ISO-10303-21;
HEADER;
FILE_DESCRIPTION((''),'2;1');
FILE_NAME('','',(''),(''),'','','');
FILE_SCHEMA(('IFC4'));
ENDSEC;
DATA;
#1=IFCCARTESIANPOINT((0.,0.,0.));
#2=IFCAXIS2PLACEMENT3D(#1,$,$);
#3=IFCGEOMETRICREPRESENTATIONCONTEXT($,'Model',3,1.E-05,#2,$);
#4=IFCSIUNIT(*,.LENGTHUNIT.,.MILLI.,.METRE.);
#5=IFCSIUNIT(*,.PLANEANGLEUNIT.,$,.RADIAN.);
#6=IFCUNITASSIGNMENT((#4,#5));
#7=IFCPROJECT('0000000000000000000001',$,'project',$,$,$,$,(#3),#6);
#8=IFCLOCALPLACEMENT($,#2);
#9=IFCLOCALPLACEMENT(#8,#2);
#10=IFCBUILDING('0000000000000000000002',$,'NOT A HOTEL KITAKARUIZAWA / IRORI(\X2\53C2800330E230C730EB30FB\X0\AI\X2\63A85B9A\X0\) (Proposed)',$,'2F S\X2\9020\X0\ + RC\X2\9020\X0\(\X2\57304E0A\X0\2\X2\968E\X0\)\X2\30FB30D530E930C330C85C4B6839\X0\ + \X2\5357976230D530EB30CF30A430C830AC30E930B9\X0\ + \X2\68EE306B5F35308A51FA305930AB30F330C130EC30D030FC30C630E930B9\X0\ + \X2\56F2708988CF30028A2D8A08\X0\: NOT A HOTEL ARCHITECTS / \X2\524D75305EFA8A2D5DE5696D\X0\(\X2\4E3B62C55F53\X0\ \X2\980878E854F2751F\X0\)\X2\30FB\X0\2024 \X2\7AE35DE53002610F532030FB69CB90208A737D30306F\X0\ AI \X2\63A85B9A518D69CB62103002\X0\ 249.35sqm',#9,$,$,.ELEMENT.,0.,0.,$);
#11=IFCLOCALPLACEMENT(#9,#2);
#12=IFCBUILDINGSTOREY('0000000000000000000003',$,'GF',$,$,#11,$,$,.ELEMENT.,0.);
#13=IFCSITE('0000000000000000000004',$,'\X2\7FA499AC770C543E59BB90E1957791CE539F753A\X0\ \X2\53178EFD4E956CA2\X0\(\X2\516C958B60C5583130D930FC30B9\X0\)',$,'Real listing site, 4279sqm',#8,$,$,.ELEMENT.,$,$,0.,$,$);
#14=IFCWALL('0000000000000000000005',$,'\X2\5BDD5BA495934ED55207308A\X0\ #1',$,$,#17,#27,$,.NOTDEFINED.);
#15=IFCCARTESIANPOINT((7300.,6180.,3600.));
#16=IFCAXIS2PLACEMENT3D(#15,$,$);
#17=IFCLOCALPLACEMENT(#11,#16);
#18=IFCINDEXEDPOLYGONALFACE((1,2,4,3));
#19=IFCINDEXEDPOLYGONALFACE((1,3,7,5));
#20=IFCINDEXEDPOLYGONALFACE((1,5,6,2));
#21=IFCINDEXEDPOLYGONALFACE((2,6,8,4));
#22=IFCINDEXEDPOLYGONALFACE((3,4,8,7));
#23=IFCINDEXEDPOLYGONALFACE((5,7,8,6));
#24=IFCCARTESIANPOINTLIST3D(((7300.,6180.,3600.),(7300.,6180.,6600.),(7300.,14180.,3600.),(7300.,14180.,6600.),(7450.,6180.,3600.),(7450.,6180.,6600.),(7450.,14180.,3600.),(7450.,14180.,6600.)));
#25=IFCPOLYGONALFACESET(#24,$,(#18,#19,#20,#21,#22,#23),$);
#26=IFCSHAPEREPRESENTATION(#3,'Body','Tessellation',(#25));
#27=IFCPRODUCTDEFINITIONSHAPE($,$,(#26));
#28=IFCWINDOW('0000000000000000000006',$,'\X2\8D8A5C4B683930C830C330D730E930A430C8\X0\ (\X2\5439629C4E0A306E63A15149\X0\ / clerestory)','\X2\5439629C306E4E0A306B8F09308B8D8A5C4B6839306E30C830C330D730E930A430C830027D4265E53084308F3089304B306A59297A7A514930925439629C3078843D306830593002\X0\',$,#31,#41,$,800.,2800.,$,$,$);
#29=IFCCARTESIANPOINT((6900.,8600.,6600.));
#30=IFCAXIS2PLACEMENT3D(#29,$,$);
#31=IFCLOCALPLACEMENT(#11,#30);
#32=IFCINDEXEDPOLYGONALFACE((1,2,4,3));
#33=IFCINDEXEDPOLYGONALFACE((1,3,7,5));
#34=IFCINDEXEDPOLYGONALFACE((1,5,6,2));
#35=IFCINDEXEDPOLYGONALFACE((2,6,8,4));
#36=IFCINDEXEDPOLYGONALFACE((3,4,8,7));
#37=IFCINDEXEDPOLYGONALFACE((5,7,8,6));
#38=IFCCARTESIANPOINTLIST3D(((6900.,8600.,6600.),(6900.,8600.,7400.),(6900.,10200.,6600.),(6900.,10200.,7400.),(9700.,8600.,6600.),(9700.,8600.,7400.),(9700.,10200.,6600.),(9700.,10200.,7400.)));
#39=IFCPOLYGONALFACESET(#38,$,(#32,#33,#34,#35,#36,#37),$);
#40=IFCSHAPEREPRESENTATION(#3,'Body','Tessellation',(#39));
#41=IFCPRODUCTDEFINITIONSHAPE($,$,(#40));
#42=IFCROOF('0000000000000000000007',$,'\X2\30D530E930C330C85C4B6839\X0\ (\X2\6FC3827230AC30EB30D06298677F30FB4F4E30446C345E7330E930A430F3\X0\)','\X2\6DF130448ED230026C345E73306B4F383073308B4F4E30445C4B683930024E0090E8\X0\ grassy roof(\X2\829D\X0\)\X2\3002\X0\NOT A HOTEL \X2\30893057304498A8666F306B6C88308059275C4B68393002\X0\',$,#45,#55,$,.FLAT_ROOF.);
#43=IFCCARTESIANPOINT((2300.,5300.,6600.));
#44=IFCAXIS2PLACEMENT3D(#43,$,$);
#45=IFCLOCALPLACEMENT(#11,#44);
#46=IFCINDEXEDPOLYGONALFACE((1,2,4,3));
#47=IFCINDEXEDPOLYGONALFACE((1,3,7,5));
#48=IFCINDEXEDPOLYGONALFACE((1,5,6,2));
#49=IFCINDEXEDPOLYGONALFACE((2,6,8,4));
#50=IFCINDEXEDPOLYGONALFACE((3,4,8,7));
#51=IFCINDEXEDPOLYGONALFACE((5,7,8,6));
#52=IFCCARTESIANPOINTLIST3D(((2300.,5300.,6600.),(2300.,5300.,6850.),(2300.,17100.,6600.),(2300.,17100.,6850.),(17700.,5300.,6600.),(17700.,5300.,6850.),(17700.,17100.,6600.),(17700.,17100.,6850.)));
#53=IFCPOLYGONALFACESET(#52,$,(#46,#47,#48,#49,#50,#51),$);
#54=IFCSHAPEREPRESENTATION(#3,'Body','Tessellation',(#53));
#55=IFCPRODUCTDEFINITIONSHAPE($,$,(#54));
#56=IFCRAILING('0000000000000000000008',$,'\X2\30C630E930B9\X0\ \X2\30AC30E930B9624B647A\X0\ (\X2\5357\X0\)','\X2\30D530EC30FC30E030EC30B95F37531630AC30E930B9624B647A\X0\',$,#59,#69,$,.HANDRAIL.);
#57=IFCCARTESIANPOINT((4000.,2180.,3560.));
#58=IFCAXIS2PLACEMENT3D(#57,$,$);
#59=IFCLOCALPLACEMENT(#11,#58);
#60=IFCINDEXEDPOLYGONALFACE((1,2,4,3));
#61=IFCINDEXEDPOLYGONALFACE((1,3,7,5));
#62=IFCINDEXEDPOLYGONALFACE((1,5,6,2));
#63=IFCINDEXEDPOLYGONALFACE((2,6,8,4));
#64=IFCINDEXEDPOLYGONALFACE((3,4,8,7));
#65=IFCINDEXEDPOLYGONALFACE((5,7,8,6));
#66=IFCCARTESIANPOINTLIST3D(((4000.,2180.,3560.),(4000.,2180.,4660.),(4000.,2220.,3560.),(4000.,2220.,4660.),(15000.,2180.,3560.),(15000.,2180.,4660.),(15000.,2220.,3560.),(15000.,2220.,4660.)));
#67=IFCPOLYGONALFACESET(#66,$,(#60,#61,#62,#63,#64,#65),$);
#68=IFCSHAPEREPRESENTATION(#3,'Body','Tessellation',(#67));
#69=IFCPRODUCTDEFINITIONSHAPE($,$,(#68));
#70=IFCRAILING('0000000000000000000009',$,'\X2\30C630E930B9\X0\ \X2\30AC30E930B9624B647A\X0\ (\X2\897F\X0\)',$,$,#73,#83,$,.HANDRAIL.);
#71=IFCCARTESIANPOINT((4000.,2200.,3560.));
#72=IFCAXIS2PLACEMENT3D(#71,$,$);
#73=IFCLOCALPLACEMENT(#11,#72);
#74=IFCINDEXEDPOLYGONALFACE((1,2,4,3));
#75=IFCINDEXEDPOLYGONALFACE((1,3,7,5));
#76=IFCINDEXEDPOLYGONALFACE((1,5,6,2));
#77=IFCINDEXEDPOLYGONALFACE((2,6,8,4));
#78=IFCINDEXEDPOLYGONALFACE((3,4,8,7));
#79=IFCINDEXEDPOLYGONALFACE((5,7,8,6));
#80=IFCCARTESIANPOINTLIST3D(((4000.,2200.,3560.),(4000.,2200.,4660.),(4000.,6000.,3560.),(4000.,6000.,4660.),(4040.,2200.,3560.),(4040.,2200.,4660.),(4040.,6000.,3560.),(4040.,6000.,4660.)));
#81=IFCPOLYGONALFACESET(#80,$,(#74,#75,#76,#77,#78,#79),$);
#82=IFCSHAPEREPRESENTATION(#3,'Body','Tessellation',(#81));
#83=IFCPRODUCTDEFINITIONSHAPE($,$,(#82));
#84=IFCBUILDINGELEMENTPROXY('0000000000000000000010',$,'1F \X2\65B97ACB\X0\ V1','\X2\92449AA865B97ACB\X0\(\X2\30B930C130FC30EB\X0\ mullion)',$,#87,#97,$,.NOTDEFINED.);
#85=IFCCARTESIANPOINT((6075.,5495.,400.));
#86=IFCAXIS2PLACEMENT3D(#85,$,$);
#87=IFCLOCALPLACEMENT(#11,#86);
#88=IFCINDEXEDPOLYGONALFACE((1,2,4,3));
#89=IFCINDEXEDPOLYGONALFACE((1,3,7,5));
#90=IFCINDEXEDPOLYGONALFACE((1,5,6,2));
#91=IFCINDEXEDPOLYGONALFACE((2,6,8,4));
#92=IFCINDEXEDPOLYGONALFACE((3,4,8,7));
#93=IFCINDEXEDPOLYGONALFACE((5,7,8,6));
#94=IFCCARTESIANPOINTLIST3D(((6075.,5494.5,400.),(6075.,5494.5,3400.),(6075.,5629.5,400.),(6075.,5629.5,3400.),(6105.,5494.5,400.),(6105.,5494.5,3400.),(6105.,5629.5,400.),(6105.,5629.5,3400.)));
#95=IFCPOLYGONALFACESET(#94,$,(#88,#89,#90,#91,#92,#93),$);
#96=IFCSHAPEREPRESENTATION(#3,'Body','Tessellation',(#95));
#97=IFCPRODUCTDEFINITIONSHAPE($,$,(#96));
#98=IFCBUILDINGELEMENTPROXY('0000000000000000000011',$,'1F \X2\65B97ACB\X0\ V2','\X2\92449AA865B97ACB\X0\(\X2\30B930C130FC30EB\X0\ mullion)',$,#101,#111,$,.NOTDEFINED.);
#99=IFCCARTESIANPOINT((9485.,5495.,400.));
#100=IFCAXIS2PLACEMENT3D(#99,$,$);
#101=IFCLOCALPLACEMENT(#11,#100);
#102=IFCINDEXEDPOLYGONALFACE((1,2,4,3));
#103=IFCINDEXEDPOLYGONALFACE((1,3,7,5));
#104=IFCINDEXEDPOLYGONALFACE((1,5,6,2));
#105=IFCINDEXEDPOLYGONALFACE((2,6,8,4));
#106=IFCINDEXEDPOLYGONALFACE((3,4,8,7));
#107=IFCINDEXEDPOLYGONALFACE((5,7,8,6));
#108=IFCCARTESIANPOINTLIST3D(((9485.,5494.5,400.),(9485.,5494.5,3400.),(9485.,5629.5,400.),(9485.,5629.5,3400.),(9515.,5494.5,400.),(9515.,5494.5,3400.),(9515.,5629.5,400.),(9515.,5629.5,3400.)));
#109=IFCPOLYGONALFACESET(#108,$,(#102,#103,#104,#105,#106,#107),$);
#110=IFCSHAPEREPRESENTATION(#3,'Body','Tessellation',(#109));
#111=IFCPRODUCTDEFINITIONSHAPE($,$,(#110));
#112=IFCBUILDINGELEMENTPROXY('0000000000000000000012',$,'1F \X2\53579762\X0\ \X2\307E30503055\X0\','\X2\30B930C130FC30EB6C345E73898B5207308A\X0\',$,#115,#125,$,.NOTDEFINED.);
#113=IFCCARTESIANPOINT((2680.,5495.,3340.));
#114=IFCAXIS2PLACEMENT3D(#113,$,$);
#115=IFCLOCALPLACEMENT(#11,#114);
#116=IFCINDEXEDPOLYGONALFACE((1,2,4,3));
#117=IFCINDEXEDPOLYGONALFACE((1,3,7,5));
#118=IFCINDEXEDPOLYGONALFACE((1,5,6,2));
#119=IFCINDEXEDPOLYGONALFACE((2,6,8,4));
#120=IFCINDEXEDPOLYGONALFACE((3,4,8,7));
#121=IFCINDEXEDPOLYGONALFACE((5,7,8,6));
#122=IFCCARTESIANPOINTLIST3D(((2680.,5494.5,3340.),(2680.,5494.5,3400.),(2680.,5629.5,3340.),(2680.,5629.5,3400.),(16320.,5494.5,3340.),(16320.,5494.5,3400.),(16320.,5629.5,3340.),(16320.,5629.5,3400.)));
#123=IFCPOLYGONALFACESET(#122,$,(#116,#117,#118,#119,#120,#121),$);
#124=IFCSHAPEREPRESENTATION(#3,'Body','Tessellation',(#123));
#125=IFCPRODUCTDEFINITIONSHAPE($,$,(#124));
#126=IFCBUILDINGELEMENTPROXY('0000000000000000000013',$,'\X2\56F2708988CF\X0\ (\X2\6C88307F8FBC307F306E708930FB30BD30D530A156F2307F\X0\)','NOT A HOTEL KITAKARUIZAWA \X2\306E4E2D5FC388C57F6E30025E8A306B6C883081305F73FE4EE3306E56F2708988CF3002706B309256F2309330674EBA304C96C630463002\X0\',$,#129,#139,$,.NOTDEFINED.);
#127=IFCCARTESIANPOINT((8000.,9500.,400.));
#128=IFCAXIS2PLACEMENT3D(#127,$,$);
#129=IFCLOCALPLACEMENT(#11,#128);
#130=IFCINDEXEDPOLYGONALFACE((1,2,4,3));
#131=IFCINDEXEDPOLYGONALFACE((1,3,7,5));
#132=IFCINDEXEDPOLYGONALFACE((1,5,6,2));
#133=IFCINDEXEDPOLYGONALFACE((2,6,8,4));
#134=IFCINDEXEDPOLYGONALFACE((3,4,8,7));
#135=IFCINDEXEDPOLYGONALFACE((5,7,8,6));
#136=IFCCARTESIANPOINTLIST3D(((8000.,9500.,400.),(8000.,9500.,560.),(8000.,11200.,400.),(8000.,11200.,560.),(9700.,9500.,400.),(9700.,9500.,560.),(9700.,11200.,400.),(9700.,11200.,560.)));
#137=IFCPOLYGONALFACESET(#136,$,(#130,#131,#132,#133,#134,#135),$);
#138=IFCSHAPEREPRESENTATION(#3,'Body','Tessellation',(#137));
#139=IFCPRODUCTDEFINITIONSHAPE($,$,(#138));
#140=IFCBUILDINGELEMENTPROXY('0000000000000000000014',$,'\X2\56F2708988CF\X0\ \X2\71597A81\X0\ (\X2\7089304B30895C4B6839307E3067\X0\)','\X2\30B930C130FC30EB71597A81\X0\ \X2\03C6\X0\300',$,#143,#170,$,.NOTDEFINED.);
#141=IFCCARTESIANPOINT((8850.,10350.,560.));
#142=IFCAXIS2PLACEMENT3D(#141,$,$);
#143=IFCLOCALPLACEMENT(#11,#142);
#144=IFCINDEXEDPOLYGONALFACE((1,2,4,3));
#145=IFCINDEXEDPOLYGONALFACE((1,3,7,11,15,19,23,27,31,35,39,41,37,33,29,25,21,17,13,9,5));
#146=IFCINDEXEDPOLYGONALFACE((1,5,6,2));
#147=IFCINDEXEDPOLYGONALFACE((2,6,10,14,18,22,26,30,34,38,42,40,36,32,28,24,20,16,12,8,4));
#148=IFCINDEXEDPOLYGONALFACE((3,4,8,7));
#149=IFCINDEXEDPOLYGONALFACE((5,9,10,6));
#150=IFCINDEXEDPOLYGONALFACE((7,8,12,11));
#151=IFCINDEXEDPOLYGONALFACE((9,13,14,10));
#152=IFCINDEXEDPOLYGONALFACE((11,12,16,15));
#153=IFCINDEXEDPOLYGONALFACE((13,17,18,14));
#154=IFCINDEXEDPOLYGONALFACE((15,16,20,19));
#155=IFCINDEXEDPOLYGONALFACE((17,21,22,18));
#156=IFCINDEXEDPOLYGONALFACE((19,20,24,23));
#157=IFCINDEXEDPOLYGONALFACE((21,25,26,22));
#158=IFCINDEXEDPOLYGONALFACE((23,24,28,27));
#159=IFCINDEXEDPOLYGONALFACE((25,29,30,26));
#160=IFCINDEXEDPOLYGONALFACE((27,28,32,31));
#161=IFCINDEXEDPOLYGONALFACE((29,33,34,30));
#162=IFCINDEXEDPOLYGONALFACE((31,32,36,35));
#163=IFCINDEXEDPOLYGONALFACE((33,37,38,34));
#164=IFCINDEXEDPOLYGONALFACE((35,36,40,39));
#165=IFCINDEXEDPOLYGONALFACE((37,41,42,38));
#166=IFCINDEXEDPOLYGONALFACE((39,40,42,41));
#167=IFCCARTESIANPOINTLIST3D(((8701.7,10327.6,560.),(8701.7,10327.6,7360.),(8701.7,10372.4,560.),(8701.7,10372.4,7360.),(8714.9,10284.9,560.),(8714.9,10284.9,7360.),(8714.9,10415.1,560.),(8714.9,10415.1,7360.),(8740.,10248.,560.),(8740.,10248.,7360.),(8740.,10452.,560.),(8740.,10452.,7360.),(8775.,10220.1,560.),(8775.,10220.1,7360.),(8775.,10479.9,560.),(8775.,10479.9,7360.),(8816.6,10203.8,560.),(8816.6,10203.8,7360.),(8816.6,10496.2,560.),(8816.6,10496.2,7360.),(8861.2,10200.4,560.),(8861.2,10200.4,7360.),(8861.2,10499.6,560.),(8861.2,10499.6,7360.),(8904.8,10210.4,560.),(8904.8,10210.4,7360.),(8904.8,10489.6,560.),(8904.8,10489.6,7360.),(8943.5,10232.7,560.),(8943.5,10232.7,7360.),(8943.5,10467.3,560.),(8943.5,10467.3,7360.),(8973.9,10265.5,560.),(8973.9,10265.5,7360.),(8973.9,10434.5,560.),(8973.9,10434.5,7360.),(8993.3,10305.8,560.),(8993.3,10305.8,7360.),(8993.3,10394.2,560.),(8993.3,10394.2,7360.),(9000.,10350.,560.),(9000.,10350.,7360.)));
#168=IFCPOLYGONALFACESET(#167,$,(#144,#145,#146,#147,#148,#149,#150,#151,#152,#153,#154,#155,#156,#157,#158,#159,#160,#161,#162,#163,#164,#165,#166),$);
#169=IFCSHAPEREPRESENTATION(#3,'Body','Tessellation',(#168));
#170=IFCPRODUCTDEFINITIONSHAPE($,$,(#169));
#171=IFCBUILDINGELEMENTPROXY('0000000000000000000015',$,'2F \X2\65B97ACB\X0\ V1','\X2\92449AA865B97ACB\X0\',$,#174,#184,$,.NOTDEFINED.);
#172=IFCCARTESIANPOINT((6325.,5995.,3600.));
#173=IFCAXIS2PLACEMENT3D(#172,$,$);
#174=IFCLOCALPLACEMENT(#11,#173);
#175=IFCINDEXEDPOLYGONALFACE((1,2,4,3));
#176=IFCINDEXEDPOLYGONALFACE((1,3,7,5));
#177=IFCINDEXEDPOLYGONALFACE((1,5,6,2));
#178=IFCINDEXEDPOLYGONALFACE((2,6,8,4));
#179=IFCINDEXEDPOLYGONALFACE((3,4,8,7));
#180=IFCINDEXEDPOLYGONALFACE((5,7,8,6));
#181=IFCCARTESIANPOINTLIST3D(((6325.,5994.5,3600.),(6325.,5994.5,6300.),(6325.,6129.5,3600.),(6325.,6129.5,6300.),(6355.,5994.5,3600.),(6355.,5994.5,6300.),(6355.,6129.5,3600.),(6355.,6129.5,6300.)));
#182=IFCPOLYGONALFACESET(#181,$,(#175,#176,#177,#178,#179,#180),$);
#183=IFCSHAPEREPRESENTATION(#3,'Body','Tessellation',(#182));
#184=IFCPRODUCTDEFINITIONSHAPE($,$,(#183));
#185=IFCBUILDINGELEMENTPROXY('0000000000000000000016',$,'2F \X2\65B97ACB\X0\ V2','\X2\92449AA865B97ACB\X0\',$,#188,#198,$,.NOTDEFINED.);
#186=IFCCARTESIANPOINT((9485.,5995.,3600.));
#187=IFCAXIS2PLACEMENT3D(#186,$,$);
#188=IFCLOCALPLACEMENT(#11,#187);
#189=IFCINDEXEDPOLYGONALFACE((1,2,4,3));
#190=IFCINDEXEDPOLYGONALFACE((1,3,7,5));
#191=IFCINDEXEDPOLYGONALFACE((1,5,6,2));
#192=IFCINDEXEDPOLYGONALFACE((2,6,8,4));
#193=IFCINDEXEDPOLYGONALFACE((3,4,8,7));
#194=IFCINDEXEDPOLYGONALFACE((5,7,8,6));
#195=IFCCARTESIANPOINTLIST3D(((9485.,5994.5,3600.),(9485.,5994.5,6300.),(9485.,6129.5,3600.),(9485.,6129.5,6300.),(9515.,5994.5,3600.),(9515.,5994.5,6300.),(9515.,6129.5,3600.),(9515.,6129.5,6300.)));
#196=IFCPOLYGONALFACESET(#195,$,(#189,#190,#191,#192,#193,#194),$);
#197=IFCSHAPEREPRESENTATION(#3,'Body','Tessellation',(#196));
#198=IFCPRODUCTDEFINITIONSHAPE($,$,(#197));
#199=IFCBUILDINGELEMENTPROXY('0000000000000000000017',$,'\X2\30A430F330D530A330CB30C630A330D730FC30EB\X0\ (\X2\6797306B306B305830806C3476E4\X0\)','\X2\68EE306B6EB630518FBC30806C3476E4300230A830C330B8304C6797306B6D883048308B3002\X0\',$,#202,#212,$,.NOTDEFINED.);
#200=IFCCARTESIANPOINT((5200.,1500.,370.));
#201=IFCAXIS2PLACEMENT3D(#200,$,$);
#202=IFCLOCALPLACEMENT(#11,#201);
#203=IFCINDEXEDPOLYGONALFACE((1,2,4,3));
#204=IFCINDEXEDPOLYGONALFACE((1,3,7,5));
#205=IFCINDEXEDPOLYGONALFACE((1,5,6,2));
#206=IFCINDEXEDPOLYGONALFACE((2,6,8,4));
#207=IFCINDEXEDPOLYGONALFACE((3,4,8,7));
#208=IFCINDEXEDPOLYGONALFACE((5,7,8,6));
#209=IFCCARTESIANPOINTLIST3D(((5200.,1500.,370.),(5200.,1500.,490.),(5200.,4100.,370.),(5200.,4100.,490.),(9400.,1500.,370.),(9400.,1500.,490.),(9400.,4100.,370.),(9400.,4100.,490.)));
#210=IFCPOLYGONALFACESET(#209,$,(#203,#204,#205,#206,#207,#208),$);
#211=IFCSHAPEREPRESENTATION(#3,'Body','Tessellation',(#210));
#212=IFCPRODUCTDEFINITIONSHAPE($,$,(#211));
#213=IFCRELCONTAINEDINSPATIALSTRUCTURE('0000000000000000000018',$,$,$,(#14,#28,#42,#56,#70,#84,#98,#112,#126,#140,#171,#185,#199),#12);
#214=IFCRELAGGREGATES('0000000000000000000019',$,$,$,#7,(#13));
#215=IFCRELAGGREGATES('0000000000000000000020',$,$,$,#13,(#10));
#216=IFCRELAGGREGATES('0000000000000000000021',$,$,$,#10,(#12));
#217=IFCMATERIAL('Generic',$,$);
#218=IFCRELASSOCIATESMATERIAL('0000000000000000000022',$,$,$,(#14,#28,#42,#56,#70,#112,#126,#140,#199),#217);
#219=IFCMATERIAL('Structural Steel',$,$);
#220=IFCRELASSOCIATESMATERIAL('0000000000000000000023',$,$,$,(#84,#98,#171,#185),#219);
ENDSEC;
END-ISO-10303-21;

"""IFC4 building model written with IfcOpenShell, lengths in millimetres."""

from ifc_helpers import new_model, si_unit, frame, frame_2d, origin, origin_2d, place, context, project, spatial, rectangle, circle, extrude, material, element, save


model = new_model("IFC4")

# Units and contexts
model_context = context("Model", 3, precision=1e-05, world=origin())
ifc_project = project(units=[si_unit("LENGTHUNIT", "METRE", prefix="MILLI"), si_unit("PLANEANGLEUNIT", "RADIAN")], contexts=[model_context])

# Site, building, storey
site_placement = place(None, origin())
site = spatial("IfcSite", under=ifc_project, at=site_placement, Name="群馬県吾妻郡長野原町 北軽井沢(公開情報ベース)", ObjectType="Real listing site, 4279sqm", CompositionType="ELEMENT", RefElevation=0.0)
building_placement = place(site_placement, origin())
building = spatial("IfcBuilding", under=site, at=building_placement, Name="NOT A HOTEL KITAKARUIZAWA / IRORI(参考モデル・AI推定) (Proposed)", ObjectType="2F S造 + RC造(地上2階)・フラット屋根 + 南面フルハイトガラス + 森に張り出すカンチレバーテラス + 囲炉裏。設計: NOT A HOTEL ARCHITECTS / 前田建設工業(主担当 須磨哲生)・2024 竣工。意匠・構造詳細は AI 推定再構成。 249.35sqm", CompositionType="ELEMENT", ElevationOfRefHeight=0.0, ElevationOfTerrain=0.0)
storey_placement = place(building_placement, origin())
storey = spatial("IfcBuildingStorey", under=building, at=storey_placement, Name="GF", CompositionType="ELEMENT", Elevation=0.0)

# Shared definitions
ifc_material_1 = material(Name="Structural Steel")

# Shared definitions
ifc_material_2 = material(Name="Generic")

# Wall
wall_1_placement = place(storey_placement, frame((7300.0, 6180.0, 3600.0)))
element("IfcWall", 1, at=wall_1_placement, inside=storey, material=ifc_material_2, Name="寝室間仕切り #1", PredefinedType="NOTDEFINED", context=model_context, shape_type="SweptSolid", body=[
    extrude(rectangle(XDim=150.0, YDim=8000.0, at=frame_2d((75.0, 4000.0))), frame((7300.0, 6180.0, 3600.0)), (0.0, 0.0, 1.0), 3000.0),
])

# Window
window_1_placement = place(storey_placement, frame((6900.0, 8600.0, 6600.0)))
element("IfcWindow", 2, at=window_1_placement, inside=storey, material=ifc_material_2, Name="越屋根トップライト (吹抜上の採光 / clerestory)", Description="吹抜の上に載る越屋根のトップライト。終日やわらかな天空光を吹抜へ落とす。", OverallHeight=800.0, OverallWidth=2800.0, context=model_context, shape_type="SweptSolid", body=[
    extrude(rectangle(XDim=2800.0, YDim=1600.0, at=frame_2d((1400.0, 800.0))), frame((6900.0, 8600.0, 6600.0)), (0.0, 0.0, 1.0), 800.0),
])

# Roof
roof_placement = place(storey_placement, frame((2300.0, 5300.0, 6600.0)))
element("IfcRoof", 3, at=roof_placement, inside=storey, material=ifc_material_2, Name="フラット屋根 (濃色ガルバ折板・低い水平ライン)", Description="深い軒。水平に伸びる低い屋根。一部 grassy roof(芝)。NOT A HOTEL らしい風景に沈む大屋根。", PredefinedType="FLAT_ROOF", context=model_context, shape_type="SweptSolid", body=[
    extrude(rectangle(XDim=15400.0, YDim=11800.0, at=frame_2d((7700.0, 5900.0))), frame((2300.0, 5300.0, 6600.0)), (0.0, 0.0, 1.0), 250.0),
])

# Railings
railing_1_placement = place(storey_placement, frame((4000.0, 2180.0, 3560.0)))
element("IfcRailing", 4, at=railing_1_placement, inside=storey, material=ifc_material_2, Name="テラス ガラス手摺 (南)", Description="フレームレス強化ガラス手摺", PredefinedType="HANDRAIL", context=model_context, shape_type="SweptSolid", body=[
    extrude(rectangle(XDim=11000.0, YDim=40.0, at=frame_2d((5500.0, 20.0))), frame((4000.0, 2180.0, 3560.0)), (0.0, 0.0, 1.0), 1100.0),
])
railing_2_placement = place(storey_placement, frame((4000.0, 2200.0, 3560.0)))
element("IfcRailing", 5, at=railing_2_placement, inside=storey, material=ifc_material_2, Name="テラス ガラス手摺 (西)", PredefinedType="HANDRAIL", context=model_context, shape_type="SweptSolid", body=[
    extrude(rectangle(XDim=40.0, YDim=3800.0, at=frame_2d((20.0, 1900.0))), frame((4000.0, 2200.0, 3560.0)), (0.0, 0.0, 1.0), 1100.0),
])

# Building element proxies
proxy_1_placement = place(storey_placement, frame((6075.0, 5495.0, 400.0)))
element("IfcBuildingElementProxy", 6, at=proxy_1_placement, inside=storey, material=ifc_material_1, Name="1F 方立 V1", Description="鉄骨方立(スチール mullion)", PredefinedType="NOTDEFINED", context=model_context, shape_type="SweptSolid", body=[
    extrude(rectangle(XDim=30.0, YDim=135.0, at=frame_2d((15.0, 67.0))), frame((6075.0, 5495.0, 400.0)), (0.0, 0.0, 1.0), 3000.0),
])
proxy_2_placement = place(storey_placement, frame((9485.0, 5495.0, 400.0)))
element("IfcBuildingElementProxy", 7, at=proxy_2_placement, inside=storey, material=ifc_material_1, Name="1F 方立 V2", Description="鉄骨方立(スチール mullion)", PredefinedType="NOTDEFINED", context=model_context, shape_type="SweptSolid", body=[
    extrude(rectangle(XDim=30.0, YDim=135.0, at=frame_2d((15.0, 67.0))), frame((9485.0, 5495.0, 400.0)), (0.0, 0.0, 1.0), 3000.0),
])
proxy_3_placement = place(storey_placement, frame((2680.0, 5495.0, 3340.0)))
element("IfcBuildingElementProxy", 8, at=proxy_3_placement, inside=storey, material=ifc_material_2, Name="1F 南面 まぐさ", Description="スチール水平見切り", PredefinedType="NOTDEFINED", context=model_context, shape_type="SweptSolid", body=[
    extrude(rectangle(XDim=13640.0, YDim=135.0, at=frame_2d((6820.0, 67.0))), frame((2680.0, 5495.0, 3340.0)), (0.0, 0.0, 1.0), 60.0),
])
proxy_4_placement = place(storey_placement, frame((8000.0, 9500.0, 400.0)))
element("IfcBuildingElementProxy", 9, at=proxy_4_placement, inside=storey, material=ifc_material_2, Name="囲炉裏 (沈み込みの炉・ソファ囲み)", Description="NOT A HOTEL KITAKARUIZAWA の中心装置。床に沈めた現代の囲炉裏。火を囲んで人が集う。", PredefinedType="NOTDEFINED", context=model_context, shape_type="SweptSolid", body=[
    extrude(rectangle(XDim=1700.0, YDim=1700.0, at=frame_2d((850.0, 850.0))), frame((8000.0, 9500.0, 400.0)), (0.0, 0.0, 1.0), 160.0),
])
proxy_5_placement = place(storey_placement, frame((8850.0, 10350.0, 560.0)))
element("IfcBuildingElementProxy", 10, at=proxy_5_placement, inside=storey, material=ifc_material_2, Name="囲炉裏 煙突 (炉から屋根まで)", Description="スチール煙突 φ300", PredefinedType="NOTDEFINED", context=model_context, shape_type="SweptSolid", body=[
    extrude(circle(Radius=150.0, at=origin_2d()), frame((8850.0, 10350.0, 560.0)), (0.0, 0.0, 1.0), 6800.0),
])
proxy_6_placement = place(storey_placement, frame((6325.0, 5995.0, 3600.0)))
element("IfcBuildingElementProxy", 11, at=proxy_6_placement, inside=storey, material=ifc_material_1, Name="2F 方立 V1", Description="鉄骨方立", PredefinedType="NOTDEFINED", context=model_context, shape_type="SweptSolid", body=[
    extrude(rectangle(XDim=30.0, YDim=135.0, at=frame_2d((15.0, 67.0))), frame((6325.0, 5995.0, 3600.0)), (0.0, 0.0, 1.0), 2700.0),
])
proxy_7_placement = place(storey_placement, frame((9485.0, 5995.0, 3600.0)))
element("IfcBuildingElementProxy", 12, at=proxy_7_placement, inside=storey, material=ifc_material_1, Name="2F 方立 V2", Description="鉄骨方立", PredefinedType="NOTDEFINED", context=model_context, shape_type="SweptSolid", body=[
    extrude(rectangle(XDim=30.0, YDim=135.0, at=frame_2d((15.0, 67.0))), frame((9485.0, 5995.0, 3600.0)), (0.0, 0.0, 1.0), 2700.0),
])
proxy_8_placement = place(storey_placement, frame((5200.0, 1500.0, 370.0)))
element("IfcBuildingElementProxy", 13, at=proxy_8_placement, inside=storey, material=ifc_material_2, Name="インフィニティプール (林ににじむ水盤)", Description="森に溶け込む水盤。エッジが林に消える。", PredefinedType="NOTDEFINED", context=model_context, shape_type="SweptSolid", body=[
    extrude(rectangle(XDim=4200.0, YDim=2600.0, at=frame_2d((2100.0, 1300.0))), frame((5200.0, 1500.0, 370.0)), (0.0, 0.0, 1.0), 120.0),
])

save(model, "model.ifc")
